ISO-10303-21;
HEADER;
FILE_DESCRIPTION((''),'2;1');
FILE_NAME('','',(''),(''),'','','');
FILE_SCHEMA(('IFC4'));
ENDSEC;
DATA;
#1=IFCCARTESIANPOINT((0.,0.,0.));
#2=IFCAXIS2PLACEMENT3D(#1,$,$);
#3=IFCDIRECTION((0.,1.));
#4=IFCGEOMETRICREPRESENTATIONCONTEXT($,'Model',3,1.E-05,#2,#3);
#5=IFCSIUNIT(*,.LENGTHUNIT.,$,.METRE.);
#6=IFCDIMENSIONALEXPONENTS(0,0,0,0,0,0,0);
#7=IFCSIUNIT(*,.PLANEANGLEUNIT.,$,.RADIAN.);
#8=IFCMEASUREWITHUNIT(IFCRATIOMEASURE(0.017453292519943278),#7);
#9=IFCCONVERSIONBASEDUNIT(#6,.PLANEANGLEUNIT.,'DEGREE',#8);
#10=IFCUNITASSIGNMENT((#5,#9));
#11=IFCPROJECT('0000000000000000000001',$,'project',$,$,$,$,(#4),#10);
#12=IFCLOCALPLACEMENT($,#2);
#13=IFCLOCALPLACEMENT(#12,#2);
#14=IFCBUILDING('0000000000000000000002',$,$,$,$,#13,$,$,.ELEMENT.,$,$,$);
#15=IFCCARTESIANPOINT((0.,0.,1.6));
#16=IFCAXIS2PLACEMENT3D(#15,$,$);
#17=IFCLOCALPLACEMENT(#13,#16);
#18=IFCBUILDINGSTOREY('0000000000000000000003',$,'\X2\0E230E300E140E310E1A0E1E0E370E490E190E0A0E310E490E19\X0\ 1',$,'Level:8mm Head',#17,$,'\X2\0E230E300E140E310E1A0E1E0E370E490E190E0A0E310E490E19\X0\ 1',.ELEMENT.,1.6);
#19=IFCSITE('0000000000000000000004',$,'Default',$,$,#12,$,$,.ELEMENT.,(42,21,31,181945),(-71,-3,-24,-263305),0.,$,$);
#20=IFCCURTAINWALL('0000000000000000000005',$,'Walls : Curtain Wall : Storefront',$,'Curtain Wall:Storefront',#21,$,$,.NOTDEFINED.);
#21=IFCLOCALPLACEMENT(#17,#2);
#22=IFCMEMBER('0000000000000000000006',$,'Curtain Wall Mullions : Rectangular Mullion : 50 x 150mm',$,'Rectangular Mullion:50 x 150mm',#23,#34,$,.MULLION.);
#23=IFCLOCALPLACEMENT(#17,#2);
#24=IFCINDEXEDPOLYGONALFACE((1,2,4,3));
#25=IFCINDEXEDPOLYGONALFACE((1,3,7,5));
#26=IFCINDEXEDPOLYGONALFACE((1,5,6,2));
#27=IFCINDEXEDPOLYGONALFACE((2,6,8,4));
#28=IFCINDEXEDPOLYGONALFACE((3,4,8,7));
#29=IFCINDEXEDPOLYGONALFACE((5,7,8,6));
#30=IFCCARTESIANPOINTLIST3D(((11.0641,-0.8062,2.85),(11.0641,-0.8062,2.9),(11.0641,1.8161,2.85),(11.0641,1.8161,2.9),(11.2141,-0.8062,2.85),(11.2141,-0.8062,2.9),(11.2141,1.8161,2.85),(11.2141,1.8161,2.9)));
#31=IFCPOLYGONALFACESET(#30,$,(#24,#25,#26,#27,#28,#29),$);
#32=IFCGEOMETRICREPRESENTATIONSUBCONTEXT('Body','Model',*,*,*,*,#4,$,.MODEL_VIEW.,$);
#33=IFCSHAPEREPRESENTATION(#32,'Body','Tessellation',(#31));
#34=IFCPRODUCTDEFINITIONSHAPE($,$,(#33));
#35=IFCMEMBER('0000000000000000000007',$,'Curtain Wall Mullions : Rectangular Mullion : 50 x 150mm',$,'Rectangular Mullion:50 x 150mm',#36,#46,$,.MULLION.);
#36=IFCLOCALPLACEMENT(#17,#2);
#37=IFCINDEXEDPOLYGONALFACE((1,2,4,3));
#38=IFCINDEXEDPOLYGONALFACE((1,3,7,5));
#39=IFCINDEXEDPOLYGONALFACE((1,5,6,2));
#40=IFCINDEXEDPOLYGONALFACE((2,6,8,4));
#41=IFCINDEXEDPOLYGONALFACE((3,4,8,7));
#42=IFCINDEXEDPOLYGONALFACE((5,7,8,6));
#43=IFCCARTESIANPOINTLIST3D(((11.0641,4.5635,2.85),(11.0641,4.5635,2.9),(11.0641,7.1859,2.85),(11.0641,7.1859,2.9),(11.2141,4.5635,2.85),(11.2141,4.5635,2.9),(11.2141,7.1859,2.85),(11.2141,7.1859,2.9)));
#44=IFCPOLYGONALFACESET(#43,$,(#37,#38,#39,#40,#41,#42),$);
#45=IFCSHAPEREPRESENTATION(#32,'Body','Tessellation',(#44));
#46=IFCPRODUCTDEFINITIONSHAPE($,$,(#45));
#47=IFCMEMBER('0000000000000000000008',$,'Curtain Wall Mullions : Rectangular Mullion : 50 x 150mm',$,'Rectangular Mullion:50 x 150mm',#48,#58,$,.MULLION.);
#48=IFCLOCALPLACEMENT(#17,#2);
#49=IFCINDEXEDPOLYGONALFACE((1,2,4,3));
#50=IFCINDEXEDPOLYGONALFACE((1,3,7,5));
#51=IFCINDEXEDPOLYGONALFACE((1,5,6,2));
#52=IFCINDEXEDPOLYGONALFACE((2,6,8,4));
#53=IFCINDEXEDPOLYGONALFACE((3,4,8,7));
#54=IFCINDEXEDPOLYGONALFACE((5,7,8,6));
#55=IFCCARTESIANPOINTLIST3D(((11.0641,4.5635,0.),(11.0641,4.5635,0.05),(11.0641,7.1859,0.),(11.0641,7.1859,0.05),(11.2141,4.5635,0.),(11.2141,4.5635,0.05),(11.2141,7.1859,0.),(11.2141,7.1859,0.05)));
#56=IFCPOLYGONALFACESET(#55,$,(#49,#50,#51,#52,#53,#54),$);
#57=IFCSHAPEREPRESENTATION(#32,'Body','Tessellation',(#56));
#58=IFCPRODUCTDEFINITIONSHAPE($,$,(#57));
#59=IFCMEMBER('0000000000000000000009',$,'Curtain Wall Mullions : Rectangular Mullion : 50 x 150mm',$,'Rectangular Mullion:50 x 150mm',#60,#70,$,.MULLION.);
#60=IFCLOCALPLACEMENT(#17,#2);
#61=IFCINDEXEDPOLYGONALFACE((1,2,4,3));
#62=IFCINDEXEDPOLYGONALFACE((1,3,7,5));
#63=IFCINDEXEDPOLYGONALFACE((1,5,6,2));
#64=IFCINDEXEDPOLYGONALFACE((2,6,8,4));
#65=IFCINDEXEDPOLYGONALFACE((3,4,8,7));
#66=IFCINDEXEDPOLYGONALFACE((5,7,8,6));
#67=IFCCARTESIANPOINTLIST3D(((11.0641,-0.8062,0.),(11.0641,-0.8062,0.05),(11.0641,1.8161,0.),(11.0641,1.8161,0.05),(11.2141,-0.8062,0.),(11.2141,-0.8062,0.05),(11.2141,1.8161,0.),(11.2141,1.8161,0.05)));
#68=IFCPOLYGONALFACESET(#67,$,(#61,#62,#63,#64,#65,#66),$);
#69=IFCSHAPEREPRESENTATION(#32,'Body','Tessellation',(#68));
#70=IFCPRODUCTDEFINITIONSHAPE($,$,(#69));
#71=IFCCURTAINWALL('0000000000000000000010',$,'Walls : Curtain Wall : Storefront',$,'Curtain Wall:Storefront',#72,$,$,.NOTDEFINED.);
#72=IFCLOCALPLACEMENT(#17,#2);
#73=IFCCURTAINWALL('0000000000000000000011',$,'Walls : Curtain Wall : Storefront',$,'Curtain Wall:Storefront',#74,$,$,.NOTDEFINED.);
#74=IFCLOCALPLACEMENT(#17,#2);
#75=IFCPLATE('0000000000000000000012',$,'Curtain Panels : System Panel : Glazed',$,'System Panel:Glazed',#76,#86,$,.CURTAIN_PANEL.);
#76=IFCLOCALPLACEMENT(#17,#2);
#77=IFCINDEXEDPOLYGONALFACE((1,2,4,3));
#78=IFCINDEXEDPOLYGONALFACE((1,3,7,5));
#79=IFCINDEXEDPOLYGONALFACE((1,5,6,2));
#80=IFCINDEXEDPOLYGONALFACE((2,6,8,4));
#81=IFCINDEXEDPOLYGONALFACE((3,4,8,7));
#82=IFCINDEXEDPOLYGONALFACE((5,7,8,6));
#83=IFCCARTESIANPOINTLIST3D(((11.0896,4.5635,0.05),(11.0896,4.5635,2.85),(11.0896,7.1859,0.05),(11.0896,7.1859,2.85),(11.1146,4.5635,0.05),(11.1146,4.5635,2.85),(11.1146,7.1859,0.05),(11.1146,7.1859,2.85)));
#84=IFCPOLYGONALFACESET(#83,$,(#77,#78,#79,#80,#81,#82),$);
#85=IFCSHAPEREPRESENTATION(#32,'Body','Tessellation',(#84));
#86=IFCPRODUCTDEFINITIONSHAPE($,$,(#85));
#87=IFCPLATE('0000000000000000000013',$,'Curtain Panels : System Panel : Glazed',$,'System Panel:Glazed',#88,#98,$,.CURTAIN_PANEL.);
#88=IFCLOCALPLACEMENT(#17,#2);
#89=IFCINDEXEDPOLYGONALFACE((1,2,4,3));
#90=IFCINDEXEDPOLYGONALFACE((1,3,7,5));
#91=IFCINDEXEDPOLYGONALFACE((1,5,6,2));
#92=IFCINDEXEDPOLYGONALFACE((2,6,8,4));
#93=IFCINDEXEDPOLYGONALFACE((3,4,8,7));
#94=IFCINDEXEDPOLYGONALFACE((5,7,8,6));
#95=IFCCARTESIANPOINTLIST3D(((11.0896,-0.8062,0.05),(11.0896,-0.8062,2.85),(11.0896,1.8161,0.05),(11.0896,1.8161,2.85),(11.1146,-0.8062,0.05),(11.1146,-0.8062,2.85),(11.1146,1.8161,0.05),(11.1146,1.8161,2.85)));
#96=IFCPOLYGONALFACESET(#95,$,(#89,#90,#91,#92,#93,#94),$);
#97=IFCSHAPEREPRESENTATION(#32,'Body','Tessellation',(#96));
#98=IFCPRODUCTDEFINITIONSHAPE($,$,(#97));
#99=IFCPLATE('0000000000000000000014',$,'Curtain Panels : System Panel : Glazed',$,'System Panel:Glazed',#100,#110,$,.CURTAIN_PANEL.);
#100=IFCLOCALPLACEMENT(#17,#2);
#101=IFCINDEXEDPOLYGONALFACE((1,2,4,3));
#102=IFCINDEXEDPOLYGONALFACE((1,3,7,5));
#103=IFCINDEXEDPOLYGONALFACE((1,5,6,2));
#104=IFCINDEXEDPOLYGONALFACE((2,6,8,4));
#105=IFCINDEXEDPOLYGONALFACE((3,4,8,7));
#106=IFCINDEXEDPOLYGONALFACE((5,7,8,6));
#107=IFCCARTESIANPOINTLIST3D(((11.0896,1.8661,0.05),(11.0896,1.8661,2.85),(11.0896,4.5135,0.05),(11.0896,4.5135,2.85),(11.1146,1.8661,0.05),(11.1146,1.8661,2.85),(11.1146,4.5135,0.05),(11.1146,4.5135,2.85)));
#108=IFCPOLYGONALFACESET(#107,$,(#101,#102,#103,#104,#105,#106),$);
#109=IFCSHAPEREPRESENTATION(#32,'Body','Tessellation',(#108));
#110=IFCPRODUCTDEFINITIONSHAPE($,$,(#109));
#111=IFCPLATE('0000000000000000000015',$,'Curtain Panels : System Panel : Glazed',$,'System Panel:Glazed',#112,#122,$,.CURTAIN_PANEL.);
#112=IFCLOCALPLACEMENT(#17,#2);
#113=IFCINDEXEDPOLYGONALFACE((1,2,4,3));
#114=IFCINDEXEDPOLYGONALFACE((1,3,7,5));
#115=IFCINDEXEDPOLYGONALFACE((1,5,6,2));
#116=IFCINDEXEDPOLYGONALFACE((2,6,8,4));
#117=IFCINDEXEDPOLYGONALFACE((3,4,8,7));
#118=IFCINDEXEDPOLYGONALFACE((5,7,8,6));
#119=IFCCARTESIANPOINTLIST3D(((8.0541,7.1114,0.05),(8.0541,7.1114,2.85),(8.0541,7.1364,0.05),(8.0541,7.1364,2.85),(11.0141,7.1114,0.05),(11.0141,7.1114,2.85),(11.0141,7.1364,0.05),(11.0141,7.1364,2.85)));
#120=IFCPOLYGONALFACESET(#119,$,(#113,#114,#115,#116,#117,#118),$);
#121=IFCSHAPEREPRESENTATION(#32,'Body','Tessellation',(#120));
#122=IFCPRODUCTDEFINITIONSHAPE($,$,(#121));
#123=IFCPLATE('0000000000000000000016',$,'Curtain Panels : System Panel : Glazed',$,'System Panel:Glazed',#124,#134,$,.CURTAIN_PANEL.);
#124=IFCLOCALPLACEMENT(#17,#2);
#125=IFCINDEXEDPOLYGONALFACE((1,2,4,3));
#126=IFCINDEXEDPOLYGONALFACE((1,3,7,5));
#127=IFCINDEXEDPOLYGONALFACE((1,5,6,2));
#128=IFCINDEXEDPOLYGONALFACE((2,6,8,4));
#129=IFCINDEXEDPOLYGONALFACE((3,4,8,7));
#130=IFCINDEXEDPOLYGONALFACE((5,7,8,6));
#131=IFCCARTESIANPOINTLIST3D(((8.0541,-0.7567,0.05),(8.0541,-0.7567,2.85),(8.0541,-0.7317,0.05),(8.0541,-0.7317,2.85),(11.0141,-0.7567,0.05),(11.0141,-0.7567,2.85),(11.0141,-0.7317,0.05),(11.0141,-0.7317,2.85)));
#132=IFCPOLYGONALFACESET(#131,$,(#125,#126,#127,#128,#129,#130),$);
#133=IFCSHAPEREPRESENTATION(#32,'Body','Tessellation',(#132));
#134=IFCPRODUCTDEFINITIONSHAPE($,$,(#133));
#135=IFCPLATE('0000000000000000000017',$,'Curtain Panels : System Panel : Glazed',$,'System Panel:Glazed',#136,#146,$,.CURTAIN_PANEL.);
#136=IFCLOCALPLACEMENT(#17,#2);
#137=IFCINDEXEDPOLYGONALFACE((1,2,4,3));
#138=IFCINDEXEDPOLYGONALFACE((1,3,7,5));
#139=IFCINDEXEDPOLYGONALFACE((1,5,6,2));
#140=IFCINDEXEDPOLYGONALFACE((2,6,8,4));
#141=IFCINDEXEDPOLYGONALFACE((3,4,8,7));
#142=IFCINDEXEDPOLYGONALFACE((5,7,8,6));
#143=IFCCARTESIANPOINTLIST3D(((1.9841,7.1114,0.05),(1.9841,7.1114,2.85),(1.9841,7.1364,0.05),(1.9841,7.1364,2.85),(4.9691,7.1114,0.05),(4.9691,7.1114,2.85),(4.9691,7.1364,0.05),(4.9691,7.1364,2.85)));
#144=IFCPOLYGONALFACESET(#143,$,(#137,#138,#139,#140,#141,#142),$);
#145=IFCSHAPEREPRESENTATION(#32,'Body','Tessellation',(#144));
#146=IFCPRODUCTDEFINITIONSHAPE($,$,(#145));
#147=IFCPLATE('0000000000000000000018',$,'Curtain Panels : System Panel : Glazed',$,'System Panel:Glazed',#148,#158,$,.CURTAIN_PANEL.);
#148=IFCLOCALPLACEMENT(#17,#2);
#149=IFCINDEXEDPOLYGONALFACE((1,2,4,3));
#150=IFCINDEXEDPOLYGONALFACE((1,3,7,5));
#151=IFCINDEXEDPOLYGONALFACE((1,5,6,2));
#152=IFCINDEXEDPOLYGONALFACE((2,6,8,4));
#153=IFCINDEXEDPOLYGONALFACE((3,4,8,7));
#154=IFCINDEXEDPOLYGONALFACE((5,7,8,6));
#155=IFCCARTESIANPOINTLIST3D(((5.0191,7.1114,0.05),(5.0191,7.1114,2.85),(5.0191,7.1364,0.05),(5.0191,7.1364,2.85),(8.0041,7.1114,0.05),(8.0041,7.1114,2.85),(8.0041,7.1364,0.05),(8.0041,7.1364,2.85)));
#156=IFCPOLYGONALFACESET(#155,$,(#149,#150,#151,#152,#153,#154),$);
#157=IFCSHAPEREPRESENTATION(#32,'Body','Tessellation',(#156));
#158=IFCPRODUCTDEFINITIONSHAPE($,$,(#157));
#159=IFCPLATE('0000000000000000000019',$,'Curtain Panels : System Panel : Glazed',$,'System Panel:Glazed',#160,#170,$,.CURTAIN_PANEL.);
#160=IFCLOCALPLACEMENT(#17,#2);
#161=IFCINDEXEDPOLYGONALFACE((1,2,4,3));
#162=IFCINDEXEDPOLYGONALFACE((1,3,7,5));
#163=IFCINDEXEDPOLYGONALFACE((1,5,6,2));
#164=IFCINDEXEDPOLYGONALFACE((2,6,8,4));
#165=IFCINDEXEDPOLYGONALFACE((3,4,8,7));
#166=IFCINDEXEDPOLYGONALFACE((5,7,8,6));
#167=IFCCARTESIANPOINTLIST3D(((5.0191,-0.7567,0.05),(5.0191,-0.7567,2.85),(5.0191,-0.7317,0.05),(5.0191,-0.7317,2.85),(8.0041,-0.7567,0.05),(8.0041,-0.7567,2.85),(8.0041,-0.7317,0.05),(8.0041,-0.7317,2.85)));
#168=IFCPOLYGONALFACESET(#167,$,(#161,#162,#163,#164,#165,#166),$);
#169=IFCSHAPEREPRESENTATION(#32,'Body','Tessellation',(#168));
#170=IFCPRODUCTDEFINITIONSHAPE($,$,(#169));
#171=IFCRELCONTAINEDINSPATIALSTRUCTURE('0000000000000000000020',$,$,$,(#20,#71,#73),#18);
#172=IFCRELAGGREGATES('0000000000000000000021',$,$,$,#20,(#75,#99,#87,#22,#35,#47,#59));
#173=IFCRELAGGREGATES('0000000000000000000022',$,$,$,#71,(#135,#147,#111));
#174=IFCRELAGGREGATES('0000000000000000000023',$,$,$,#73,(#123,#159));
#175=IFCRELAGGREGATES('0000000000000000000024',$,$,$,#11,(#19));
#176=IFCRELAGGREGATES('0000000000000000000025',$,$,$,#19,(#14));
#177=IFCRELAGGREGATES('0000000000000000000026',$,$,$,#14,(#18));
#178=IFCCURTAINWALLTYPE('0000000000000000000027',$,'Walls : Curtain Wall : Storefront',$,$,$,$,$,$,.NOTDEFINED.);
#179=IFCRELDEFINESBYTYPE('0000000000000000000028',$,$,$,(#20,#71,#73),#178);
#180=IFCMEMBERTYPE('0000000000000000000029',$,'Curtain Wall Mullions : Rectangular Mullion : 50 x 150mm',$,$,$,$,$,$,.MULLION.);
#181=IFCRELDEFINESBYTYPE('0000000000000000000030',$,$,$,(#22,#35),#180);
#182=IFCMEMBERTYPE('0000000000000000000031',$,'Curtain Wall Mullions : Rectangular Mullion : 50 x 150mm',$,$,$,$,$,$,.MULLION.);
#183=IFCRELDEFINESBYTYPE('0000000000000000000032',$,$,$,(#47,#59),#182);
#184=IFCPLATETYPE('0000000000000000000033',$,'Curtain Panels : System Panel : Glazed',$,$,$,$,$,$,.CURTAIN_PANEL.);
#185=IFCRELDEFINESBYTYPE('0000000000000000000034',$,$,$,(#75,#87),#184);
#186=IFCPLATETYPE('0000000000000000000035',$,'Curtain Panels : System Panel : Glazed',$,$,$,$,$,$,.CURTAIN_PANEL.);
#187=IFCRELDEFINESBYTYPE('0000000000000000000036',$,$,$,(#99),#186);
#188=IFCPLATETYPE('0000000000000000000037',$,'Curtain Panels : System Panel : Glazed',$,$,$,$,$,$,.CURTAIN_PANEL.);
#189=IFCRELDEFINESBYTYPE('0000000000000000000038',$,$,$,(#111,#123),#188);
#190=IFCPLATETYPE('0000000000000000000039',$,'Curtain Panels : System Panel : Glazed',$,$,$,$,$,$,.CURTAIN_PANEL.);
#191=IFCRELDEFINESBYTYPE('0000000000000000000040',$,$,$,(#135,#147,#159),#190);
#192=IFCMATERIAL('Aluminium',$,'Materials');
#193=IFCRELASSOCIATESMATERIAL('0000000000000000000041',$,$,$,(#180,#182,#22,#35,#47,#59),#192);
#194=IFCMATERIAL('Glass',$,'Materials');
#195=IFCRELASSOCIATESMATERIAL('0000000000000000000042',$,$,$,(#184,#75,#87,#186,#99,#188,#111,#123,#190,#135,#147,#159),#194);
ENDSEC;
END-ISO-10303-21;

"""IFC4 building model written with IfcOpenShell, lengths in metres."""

from ifc_helpers import new_model, entity, si_unit, converted_unit, direction, frame, frame_2d, origin, origin_2d_with_axis, place, context, subcontext, project, spatial, polyline, segment, composite_curve, rectangle, outline, extrude, source, transform, mapped, material, material_profile, profile_set, profile_usage, type_object, type_shapes, element, aggregate, save


model = new_model("IFC4")

# Units and contexts
model_context = context("Model", 3, precision=1e-05, world=origin(), true_north=direction((0.0, 1.0)))
body_context = subcontext(model_context, "Body", "Model", "MODEL_VIEW")
ifc_project = project(units=[si_unit("LENGTHUNIT", "METRE"), converted_unit("PLANEANGLEUNIT", "DEGREE", entity("IfcRatioMeasure", 0.017453292519943278), si_unit("PLANEANGLEUNIT", "RADIAN"), dimensions=[0, 0, 0, 0, 0, 0, 0])], contexts=[model_context])

# Site, building, storey
site_placement = place(None, origin())
site = spatial("IfcSite", under=ifc_project, at=site_placement, Name="Default", CompositionType="ELEMENT", RefLatitude=(42, 21, 31, 181945), RefLongitude=(-71, -3, -24, -263305), RefElevation=0.0)
building_placement = place(site_placement, origin())
building = spatial("IfcBuilding", under=site, at=building_placement, CompositionType="ELEMENT")
storey_placement = place(building_placement, frame((0.0, 0.0, 1.6)))
storey = spatial("IfcBuildingStorey", under=building, at=storey_placement, Name="ระดับพื้นชั้น 1", ObjectType="Level:8mm Head", LongName="ระดับพื้นชั้น 1", CompositionType="ELEMENT", Elevation=1.6)

# Curtain wall, members
curtain_wall_type = type_object("IfcCurtainWallType", Name="Walls : Curtain Wall : Storefront", PredefinedType="NOTDEFINED")
curtain_wall_1_placement = place(storey_placement, frame((0.0, 0.0, -1.6)))
curtain_wall_1 = element("IfcCurtainWall", 1, at=curtain_wall_1_placement, inside=storey, type_object=curtain_wall_type, Name="Walls : Curtain Wall : Storefront", ObjectType="Curtain Wall:Storefront", PredefinedType="NOTDEFINED")
ifc_material_1 = material(Name="Aluminium", Category="Materials")
ifc_material_profile = material_profile(ifc_material_1, outline(composite_curve([segment(polyline([(0.0, 0.075, -2.6224), (0.0, -0.075, -2.6224)]), True, "CONTINUOUS"), segment(polyline([(0.0, -0.075, -2.6224), (-0.05, -0.075, -2.6224)]), True, "CONTINUOUS"), segment(polyline([(-0.05, -0.075, -2.6224), (-0.05, 0.075, -2.6224)]), True, "CONTINUOUS"), segment(polyline([(-0.05, 0.075, -2.6224), (0.0, 0.075, -2.6224)]), True, "CONTINUOUS")], self_intersect=False), kind="CURVE"), Name="50 x 150mm")
ifc_profile_set = profile_set([ifc_material_profile], Name="50 x 150mm")
ifc_profile_usage_1 = profile_usage(ifc_profile_set)
member_type_1 = type_object("IfcMemberType", Name="Curtain Wall Mullions : Rectangular Mullion : 50 x 150mm", PredefinedType="MULLION", material=ifc_profile_set)
shared_shape_1 = source(origin(), body_context, "Body", "SweptSolid", [
    extrude(rectangle(XDim=0.15, YDim=0.05, at=origin_2d_with_axis()), frame((-0.025, 0.0, -2.6224), z_axis=(0.0, 0.0, 1.0), x_axis=(0.0, -1.0, 0.0)), (0.0, 0.0, 1.0), 2.6224),
])
type_shapes(member_type_1, [shared_shape_1])
member_1_placement = place(curtain_wall_1_placement, frame((11.1391, -0.8062, 4.5), z_axis=(0.0, -1.0, 0.0), x_axis=(0.0, 0.0, 1.0)))
member_1 = element("IfcMember", 2, at=member_1_placement, type_object=member_type_1, material=ifc_profile_usage_1, Name="Curtain Wall Mullions : Rectangular Mullion : 50 x 150mm", ObjectType="Rectangular Mullion:50 x 150mm", PredefinedType="MULLION", context=body_context, shape_type="MappedRepresentation", body=[
    mapped(shared_shape_1, transform((0.0, 0.0, 0.0), scale=1.0)),
])
ifc_profile_usage_2 = profile_usage(ifc_profile_set)
member_2_placement = place(curtain_wall_1_placement, frame((11.1391, 4.5635, 4.5), z_axis=(0.0, -1.0, 0.0), x_axis=(0.0, 0.0, 1.0)))
member_2 = element("IfcMember", 3, at=member_2_placement, type_object=member_type_1, material=ifc_profile_usage_2, Name="Curtain Wall Mullions : Rectangular Mullion : 50 x 150mm", ObjectType="Rectangular Mullion:50 x 150mm", PredefinedType="MULLION", context=body_context, shape_type="MappedRepresentation", body=[
    mapped(shared_shape_1, transform((0.0, 0.0, 0.0), scale=1.0)),
])
ifc_profile_usage_3 = profile_usage(ifc_profile_set)
member_type_2 = type_object("IfcMemberType", Name="Curtain Wall Mullions : Rectangular Mullion : 50 x 150mm", PredefinedType="MULLION", material=ifc_profile_set)
shared_shape_2 = source(origin(), body_context, "Body", "SweptSolid", [
    extrude(rectangle(XDim=0.15, YDim=0.05, at=origin_2d_with_axis()), frame((-0.025, 0.0, -2.6224), z_axis=(0.0, 0.0, 1.0), x_axis=(0.0, -1.0, 0.0)), (0.0, 0.0, 1.0), 2.6224),
])
type_shapes(member_type_2, [shared_shape_2])
member_3_placement = place(curtain_wall_1_placement, frame((11.1391, 7.1859, 1.6), z_axis=(0.0, 1.0, 0.0), x_axis=(0.0, 0.0, -1.0)))
member_3 = element("IfcMember", 4, at=member_3_placement, type_object=member_type_2, material=ifc_profile_usage_3, Name="Curtain Wall Mullions : Rectangular Mullion : 50 x 150mm", ObjectType="Rectangular Mullion:50 x 150mm", PredefinedType="MULLION", context=body_context, shape_type="MappedRepresentation", body=[
    mapped(shared_shape_2, transform((0.0, 0.0, 0.0), scale=1.0)),
])
ifc_profile_usage_4 = profile_usage(ifc_profile_set)
member_4_placement = place(curtain_wall_1_placement, frame((11.1391, 1.8161, 1.6), z_axis=(0.0, 1.0, 0.0), x_axis=(0.0, 0.0, -1.0)))
member_4 = element("IfcMember", 5, at=member_4_placement, type_object=member_type_2, material=ifc_profile_usage_4, Name="Curtain Wall Mullions : Rectangular Mullion : 50 x 150mm", ObjectType="Rectangular Mullion:50 x 150mm", PredefinedType="MULLION", context=body_context, shape_type="MappedRepresentation", body=[
    mapped(shared_shape_2, transform((0.0, 0.0, 0.0), scale=1.0)),
])

# Curtain wall
curtain_wall_2_placement = place(storey_placement, frame((0.0, 0.0, -1.6)))
curtain_wall_2 = element("IfcCurtainWall", 6, at=curtain_wall_2_placement, inside=storey, type_object=curtain_wall_type, Name="Walls : Curtain Wall : Storefront", ObjectType="Curtain Wall:Storefront", PredefinedType="NOTDEFINED")

# Curtain wall
curtain_wall_3_placement = place(storey_placement, frame((0.0, 0.0, -1.6)))
curtain_wall_3 = element("IfcCurtainWall", 7, at=curtain_wall_3_placement, inside=storey, type_object=curtain_wall_type, Name="Walls : Curtain Wall : Storefront", ObjectType="Curtain Wall:Storefront", PredefinedType="NOTDEFINED")

# Plates
ifc_material_2 = material(Name="Glass", Category="Materials")
plate_type_1 = type_object("IfcPlateType", Name="Curtain Panels : System Panel : Glazed", PredefinedType="CURTAIN_PANEL", material=ifc_material_2)
shared_shape_3 = source(origin(), body_context, "Body", "SweptSolid", [
    extrude(rectangle(XDim=0.025, YDim=2.6224, at=frame_2d((0.0, 0.0), x_axis=(1.0, 0.0))), frame((1.3112, 0.0125, 0.0), z_axis=(0.0, 0.0, 1.0), x_axis=(0.0, 1.0, 0.0)), (0.0, 0.0, 1.0), 2.8),
])
type_shapes(plate_type_1, [shared_shape_3])
plate_1_placement = place(curtain_wall_1_placement, frame((11.0896, 7.1859, 1.65), z_axis=(0.0, 0.0, 1.0), x_axis=(0.0, -1.0, 0.0)))
plate_1 = element("IfcPlate", 8, at=plate_1_placement, type_object=plate_type_1, material=ifc_material_2, Name="Curtain Panels : System Panel : Glazed", ObjectType="System Panel:Glazed", PredefinedType="CURTAIN_PANEL", context=body_context, shape_type="MappedRepresentation", body=[
    mapped(shared_shape_3, transform((0.0, 0.0, 0.0), scale=1.0)),
])
plate_2_placement = place(curtain_wall_1_placement, frame((11.0896, 1.8161, 1.65), z_axis=(0.0, 0.0, 1.0), x_axis=(0.0, -1.0, 0.0)))
plate_2 = element("IfcPlate", 9, at=plate_2_placement, type_object=plate_type_1, material=ifc_material_2, Name="Curtain Panels : System Panel : Glazed", ObjectType="System Panel:Glazed", PredefinedType="CURTAIN_PANEL", context=body_context, shape_type="MappedRepresentation", body=[
    mapped(shared_shape_3, transform((0.0, 0.0, 0.0), scale=1.0)),
])
plate_type_2 = type_object("IfcPlateType", Name="Curtain Panels : System Panel : Glazed", PredefinedType="CURTAIN_PANEL", material=ifc_material_2)
shared_shape_4 = source(origin(), body_context, "Body", "SweptSolid", [
    extrude(rectangle(XDim=0.025, YDim=2.6474, at=origin_2d_with_axis()), frame((1.3237, 0.0125, 0.0), z_axis=(0.0, 0.0, 1.0), x_axis=(0.0, 1.0, 0.0)), (0.0, 0.0, 1.0), 2.8),
])
type_shapes(plate_type_2, [shared_shape_4])
plate_3_placement = place(curtain_wall_1_placement, frame((11.0896, 4.5135, 1.65), z_axis=(0.0, 0.0, 1.0), x_axis=(0.0, -1.0, 0.0)))
plate_3 = element("IfcPlate", 10, at=plate_3_placement, type_object=plate_type_2, material=ifc_material_2, Name="Curtain Panels : System Panel : Glazed", ObjectType="System Panel:Glazed", PredefinedType="CURTAIN_PANEL", context=body_context, shape_type="MappedRepresentation", body=[
    mapped(shared_shape_4, transform((0.0, 0.0, 0.0), scale=1.0)),
])
aggregate(curtain_wall_1, [plate_1, plate_3, plate_2, member_1, member_2, member_3, member_4])
plate_type_3 = type_object("IfcPlateType", Name="Curtain Panels : System Panel : Glazed", PredefinedType="CURTAIN_PANEL", material=ifc_material_2)
shared_shape_5 = source(origin(), body_context, "Body", "SweptSolid", [
    extrude(rectangle(XDim=0.025, YDim=2.96, at=frame_2d((0.0, 0.0), x_axis=(1.0, 0.0))), frame((1.48, 0.0125, 0.0), z_axis=(0.0, 0.0, 1.0), x_axis=(0.0, 1.0, 0.0)), (0.0, 0.0, 1.0), 2.8),
])
type_shapes(plate_type_3, [shared_shape_5])
plate_4_placement = place(curtain_wall_2_placement, frame((8.0541, 7.1114, 1.65)))
plate_4 = element("IfcPlate", 11, at=plate_4_placement, type_object=plate_type_3, material=ifc_material_2, Name="Curtain Panels : System Panel : Glazed", ObjectType="System Panel:Glazed", PredefinedType="CURTAIN_PANEL", context=body_context, shape_type="MappedRepresentation", body=[
    mapped(shared_shape_5, transform((0.0, 0.0, 0.0), scale=1.0)),
])
plate_5_placement = place(curtain_wall_3_placement, frame((11.0141, -0.7317, 1.65), z_axis=(0.0, 0.0, 1.0), x_axis=(-1.0, 0.0, 0.0)))
plate_5 = element("IfcPlate", 12, at=plate_5_placement, type_object=plate_type_3, material=ifc_material_2, Name="Curtain Panels : System Panel : Glazed", ObjectType="System Panel:Glazed", PredefinedType="CURTAIN_PANEL", context=body_context, shape_type="MappedRepresentation", body=[
    mapped(shared_shape_5, transform((0.0, 0.0, 0.0), scale=1.0)),
])
plate_type_4 = type_object("IfcPlateType", Name="Curtain Panels : System Panel : Glazed", PredefinedType="CURTAIN_PANEL", material=ifc_material_2)
shared_shape_6 = source(origin(), body_context, "Body", "SweptSolid", [
    extrude(rectangle(XDim=0.025, YDim=2.985, at=frame_2d((0.0, 0.0), x_axis=(1.0, 0.0))), frame((1.4925, 0.0125, 0.0), z_axis=(0.0, 0.0, 1.0), x_axis=(0.0, 1.0, 0.0)), (0.0, 0.0, 1.0), 2.8),
])
type_shapes(plate_type_4, [shared_shape_6])
plate_6_placement = place(curtain_wall_2_placement, frame((1.9841, 7.1114, 1.65)))
plate_6 = element("IfcPlate", 13, at=plate_6_placement, type_object=plate_type_4, material=ifc_material_2, Name="Curtain Panels : System Panel : Glazed", ObjectType="System Panel:Glazed", PredefinedType="CURTAIN_PANEL", context=body_context, shape_type="MappedRepresentation", body=[
    mapped(shared_shape_6, transform((0.0, 0.0, 0.0), scale=1.0)),
])
plate_7_placement = place(curtain_wall_2_placement, frame((5.0191, 7.1114, 1.65)))
plate_7 = element("IfcPlate", 14, at=plate_7_placement, type_object=plate_type_4, material=ifc_material_2, Name="Curtain Panels : System Panel : Glazed", ObjectType="System Panel:Glazed", PredefinedType="CURTAIN_PANEL", context=body_context, shape_type="MappedRepresentation", body=[
    mapped(shared_shape_6, transform((0.0, 0.0, 0.0), scale=1.0)),
])
aggregate(curtain_wall_2, [plate_6, plate_7, plate_4])
plate_8_placement = place(curtain_wall_3_placement, frame((8.0041, -0.7317, 1.65), z_axis=(0.0, 0.0, 1.0), x_axis=(-1.0, 0.0, 0.0)))
plate_8 = element("IfcPlate", 15, at=plate_8_placement, type_object=plate_type_4, material=ifc_material_2, Name="Curtain Panels : System Panel : Glazed", ObjectType="System Panel:Glazed", PredefinedType="CURTAIN_PANEL", context=body_context, shape_type="MappedRepresentation", body=[
    mapped(shared_shape_6, transform((0.0, 0.0, 0.0), scale=1.0)),
])
aggregate(curtain_wall_3, [plate_5, plate_8])

save(model, "model.ifc")
